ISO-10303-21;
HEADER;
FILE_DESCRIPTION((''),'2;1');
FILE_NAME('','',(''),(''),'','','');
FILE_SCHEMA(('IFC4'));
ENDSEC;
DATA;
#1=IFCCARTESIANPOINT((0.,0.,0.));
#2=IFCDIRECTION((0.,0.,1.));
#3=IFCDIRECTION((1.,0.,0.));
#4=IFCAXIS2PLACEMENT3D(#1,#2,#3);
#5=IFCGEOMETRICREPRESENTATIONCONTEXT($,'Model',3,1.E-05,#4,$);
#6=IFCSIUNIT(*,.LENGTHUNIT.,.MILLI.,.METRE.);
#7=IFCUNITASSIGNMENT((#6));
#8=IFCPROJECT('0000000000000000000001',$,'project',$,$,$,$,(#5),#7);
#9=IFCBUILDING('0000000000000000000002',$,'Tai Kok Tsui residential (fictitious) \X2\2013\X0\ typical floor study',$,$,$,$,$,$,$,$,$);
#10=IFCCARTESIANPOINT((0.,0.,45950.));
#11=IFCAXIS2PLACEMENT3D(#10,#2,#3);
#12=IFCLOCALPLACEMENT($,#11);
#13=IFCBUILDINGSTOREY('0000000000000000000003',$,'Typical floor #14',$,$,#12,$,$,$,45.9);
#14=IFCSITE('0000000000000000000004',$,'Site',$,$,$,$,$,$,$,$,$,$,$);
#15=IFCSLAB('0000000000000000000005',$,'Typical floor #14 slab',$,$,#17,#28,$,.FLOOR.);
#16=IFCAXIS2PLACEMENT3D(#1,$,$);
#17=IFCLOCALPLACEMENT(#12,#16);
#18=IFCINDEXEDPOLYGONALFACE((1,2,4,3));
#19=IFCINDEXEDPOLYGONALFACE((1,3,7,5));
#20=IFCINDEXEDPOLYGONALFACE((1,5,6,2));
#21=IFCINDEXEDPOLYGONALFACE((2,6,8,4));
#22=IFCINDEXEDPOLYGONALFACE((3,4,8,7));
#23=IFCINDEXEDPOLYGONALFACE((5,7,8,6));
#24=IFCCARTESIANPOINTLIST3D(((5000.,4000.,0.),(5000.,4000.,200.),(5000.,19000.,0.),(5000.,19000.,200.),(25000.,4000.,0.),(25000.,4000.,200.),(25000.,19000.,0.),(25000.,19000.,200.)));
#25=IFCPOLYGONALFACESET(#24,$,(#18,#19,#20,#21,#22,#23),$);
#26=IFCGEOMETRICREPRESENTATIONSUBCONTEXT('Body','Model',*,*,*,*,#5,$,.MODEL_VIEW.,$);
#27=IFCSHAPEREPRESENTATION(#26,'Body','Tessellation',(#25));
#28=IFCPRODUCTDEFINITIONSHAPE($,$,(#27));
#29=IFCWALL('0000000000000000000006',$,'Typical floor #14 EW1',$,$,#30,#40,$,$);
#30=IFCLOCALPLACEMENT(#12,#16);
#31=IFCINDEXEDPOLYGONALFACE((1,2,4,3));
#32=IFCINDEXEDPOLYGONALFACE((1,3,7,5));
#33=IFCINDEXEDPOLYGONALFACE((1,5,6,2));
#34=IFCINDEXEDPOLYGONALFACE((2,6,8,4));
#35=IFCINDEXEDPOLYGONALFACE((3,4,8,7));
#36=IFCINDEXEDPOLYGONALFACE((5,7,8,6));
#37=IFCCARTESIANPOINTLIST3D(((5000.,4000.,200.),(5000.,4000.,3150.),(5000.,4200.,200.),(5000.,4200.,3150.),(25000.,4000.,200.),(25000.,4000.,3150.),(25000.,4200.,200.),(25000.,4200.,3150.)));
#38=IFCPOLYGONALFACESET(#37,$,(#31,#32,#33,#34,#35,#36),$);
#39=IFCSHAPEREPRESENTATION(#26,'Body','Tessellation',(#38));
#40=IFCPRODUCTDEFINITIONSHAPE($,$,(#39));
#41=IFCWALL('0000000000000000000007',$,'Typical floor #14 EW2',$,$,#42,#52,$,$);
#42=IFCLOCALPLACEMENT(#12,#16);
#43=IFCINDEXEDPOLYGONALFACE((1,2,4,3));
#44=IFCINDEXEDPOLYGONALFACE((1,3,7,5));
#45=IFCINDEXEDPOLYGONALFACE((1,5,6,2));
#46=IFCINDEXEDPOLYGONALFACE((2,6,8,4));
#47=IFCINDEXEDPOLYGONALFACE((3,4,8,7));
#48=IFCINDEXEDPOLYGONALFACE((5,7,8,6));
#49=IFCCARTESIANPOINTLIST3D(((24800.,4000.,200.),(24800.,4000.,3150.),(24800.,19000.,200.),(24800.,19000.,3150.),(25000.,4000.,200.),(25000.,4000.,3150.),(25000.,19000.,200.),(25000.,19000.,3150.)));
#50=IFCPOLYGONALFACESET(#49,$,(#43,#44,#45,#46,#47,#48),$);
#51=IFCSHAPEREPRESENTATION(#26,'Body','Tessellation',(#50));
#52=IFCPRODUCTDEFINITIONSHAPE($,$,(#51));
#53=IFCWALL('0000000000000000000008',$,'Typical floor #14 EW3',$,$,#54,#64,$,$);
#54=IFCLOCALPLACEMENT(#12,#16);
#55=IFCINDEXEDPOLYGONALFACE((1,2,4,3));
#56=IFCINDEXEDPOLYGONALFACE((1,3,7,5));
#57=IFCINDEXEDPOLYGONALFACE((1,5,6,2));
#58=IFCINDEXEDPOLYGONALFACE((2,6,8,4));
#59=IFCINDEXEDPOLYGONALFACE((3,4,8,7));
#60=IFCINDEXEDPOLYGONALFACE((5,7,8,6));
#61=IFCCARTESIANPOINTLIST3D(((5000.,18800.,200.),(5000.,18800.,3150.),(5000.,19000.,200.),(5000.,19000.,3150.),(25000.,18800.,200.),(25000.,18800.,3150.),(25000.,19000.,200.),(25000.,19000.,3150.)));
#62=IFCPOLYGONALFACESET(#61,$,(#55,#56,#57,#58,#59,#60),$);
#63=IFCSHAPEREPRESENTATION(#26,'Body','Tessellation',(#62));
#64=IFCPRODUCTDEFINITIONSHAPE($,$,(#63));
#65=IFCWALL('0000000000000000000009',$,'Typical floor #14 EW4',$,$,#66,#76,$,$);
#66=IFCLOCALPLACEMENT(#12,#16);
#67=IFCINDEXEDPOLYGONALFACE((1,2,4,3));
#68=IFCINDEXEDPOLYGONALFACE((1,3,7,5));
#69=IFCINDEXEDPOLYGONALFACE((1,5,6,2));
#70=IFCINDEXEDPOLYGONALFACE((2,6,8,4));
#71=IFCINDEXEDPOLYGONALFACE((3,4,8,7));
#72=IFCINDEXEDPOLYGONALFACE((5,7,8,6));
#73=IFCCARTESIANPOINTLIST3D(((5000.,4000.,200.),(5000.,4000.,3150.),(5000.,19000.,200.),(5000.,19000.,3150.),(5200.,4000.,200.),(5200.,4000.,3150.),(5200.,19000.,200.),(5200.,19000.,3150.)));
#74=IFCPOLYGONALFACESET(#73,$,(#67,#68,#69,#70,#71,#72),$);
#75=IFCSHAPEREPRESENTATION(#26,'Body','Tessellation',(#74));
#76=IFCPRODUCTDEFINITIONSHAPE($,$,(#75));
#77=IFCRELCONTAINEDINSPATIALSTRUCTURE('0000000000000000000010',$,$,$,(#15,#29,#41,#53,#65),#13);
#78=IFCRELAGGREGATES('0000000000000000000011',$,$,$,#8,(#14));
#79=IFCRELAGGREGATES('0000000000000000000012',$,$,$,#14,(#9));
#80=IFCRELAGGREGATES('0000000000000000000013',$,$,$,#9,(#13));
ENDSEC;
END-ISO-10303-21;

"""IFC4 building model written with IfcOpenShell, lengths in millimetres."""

from ifc_helpers import new_model, si_unit, frame, origin_with_axes, place, context, subcontext, project, spatial, indexed_curve, outline, extrude, element, save


model = new_model("IFC4")

# Units and contexts
model_context = context("Model", 3, precision=1e-05, world=origin_with_axes())
body_context = subcontext(model_context, "Body", "Model", "MODEL_VIEW")
ifc_project = project(units=[si_unit("LENGTHUNIT", "METRE", prefix="MILLI")], contexts=[model_context])

# Site, building, storey
site = spatial("IfcSite", under=ifc_project, Name="Site")
building = spatial("IfcBuilding", under=site, Name="Tai Kok Tsui residential (fictitious) – typical floor study")
storey_placement = place(None, frame((0.0, 0.0, 45950.0), z_axis=(0.0, 0.0, 1.0), x_axis=(1.0, 0.0, 0.0)))
storey = spatial("IfcBuildingStorey", under=building, at=storey_placement, Name="Typical floor #14", Elevation=45.9)

# Slab
slab_placement = place(storey_placement, origin_with_axes())
element("IfcSlab", 1, at=slab_placement, inside=storey, Name="Typical floor #14 slab", PredefinedType="FLOOR", context=body_context, shape_type="SweptSolid", body=[
    extrude(outline(indexed_curve([(5000.0, 4000.0), (25000.0, 4000.0), (25000.0, 19000.0), (5000.0, 19000.0)])), None, (0.0, 0.0, 1.0), 200.0),
])

# Walls
wall_1_placement = place(storey_placement, frame((5000.0, 4000.0, 200.0), z_axis=(0.0, 0.0, 1.0), x_axis=(1.0, 0.0, 0.0)))
element("IfcWall", 2, at=wall_1_placement, inside=storey, Name="Typical floor #14 EW1", context=body_context, shape_type="SweptSolid", body=[
    extrude(outline(indexed_curve([(0.0, 0.0), (0.0, 200.0), (20000.0, 200.0), (20000.0, 0.0), (0.0, 0.0)], self_intersect=False)), origin_with_axes(), (0.0, 0.0, 1.0), 2950.0),
])
wall_2_placement = place(storey_placement, frame((25000.0, 4000.0, 200.0), z_axis=(0.0, 0.0, 1.0), x_axis=(0.0, 1.0, 0.0)))
element("IfcWall", 3, at=wall_2_placement, inside=storey, Name="Typical floor #14 EW2", context=body_context, shape_type="SweptSolid", body=[
    extrude(outline(indexed_curve([(0.0, 0.0), (0.0, 200.0), (15000.0, 200.0), (15000.0, 0.0), (0.0, 0.0)], self_intersect=False)), origin_with_axes(), (0.0, 0.0, 1.0), 2950.0),
])
wall_3_placement = place(storey_placement, frame((25000.0, 19000.0, 200.0), z_axis=(0.0, 0.0, 1.0), x_axis=(-1.0, 0.0, 0.0)))
element("IfcWall", 4, at=wall_3_placement, inside=storey, Name="Typical floor #14 EW3", context=body_context, shape_type="SweptSolid", body=[
    extrude(outline(indexed_curve([(0.0, 0.0), (0.0, 200.0), (20000.0, 200.0), (20000.0, 0.0), (0.0, 0.0)], self_intersect=False)), origin_with_axes(), (0.0, 0.0, 1.0), 2950.0),
])
wall_4_placement = place(storey_placement, frame((5000.0, 19000.0, 200.0), z_axis=(0.0, 0.0, 1.0), x_axis=(0.0, -1.0, 0.0)))
element("IfcWall", 5, at=wall_4_placement, inside=storey, Name="Typical floor #14 EW4", context=body_context, shape_type="SweptSolid", body=[
    extrude(outline(indexed_curve([(0.0, 0.0), (0.0, 200.0), (15000.0, 200.0), (15000.0, 0.0), (0.0, 0.0)], self_intersect=False)), origin_with_axes(), (0.0, 0.0, 1.0), 2950.0),
])

save(model, "model.ifc")
